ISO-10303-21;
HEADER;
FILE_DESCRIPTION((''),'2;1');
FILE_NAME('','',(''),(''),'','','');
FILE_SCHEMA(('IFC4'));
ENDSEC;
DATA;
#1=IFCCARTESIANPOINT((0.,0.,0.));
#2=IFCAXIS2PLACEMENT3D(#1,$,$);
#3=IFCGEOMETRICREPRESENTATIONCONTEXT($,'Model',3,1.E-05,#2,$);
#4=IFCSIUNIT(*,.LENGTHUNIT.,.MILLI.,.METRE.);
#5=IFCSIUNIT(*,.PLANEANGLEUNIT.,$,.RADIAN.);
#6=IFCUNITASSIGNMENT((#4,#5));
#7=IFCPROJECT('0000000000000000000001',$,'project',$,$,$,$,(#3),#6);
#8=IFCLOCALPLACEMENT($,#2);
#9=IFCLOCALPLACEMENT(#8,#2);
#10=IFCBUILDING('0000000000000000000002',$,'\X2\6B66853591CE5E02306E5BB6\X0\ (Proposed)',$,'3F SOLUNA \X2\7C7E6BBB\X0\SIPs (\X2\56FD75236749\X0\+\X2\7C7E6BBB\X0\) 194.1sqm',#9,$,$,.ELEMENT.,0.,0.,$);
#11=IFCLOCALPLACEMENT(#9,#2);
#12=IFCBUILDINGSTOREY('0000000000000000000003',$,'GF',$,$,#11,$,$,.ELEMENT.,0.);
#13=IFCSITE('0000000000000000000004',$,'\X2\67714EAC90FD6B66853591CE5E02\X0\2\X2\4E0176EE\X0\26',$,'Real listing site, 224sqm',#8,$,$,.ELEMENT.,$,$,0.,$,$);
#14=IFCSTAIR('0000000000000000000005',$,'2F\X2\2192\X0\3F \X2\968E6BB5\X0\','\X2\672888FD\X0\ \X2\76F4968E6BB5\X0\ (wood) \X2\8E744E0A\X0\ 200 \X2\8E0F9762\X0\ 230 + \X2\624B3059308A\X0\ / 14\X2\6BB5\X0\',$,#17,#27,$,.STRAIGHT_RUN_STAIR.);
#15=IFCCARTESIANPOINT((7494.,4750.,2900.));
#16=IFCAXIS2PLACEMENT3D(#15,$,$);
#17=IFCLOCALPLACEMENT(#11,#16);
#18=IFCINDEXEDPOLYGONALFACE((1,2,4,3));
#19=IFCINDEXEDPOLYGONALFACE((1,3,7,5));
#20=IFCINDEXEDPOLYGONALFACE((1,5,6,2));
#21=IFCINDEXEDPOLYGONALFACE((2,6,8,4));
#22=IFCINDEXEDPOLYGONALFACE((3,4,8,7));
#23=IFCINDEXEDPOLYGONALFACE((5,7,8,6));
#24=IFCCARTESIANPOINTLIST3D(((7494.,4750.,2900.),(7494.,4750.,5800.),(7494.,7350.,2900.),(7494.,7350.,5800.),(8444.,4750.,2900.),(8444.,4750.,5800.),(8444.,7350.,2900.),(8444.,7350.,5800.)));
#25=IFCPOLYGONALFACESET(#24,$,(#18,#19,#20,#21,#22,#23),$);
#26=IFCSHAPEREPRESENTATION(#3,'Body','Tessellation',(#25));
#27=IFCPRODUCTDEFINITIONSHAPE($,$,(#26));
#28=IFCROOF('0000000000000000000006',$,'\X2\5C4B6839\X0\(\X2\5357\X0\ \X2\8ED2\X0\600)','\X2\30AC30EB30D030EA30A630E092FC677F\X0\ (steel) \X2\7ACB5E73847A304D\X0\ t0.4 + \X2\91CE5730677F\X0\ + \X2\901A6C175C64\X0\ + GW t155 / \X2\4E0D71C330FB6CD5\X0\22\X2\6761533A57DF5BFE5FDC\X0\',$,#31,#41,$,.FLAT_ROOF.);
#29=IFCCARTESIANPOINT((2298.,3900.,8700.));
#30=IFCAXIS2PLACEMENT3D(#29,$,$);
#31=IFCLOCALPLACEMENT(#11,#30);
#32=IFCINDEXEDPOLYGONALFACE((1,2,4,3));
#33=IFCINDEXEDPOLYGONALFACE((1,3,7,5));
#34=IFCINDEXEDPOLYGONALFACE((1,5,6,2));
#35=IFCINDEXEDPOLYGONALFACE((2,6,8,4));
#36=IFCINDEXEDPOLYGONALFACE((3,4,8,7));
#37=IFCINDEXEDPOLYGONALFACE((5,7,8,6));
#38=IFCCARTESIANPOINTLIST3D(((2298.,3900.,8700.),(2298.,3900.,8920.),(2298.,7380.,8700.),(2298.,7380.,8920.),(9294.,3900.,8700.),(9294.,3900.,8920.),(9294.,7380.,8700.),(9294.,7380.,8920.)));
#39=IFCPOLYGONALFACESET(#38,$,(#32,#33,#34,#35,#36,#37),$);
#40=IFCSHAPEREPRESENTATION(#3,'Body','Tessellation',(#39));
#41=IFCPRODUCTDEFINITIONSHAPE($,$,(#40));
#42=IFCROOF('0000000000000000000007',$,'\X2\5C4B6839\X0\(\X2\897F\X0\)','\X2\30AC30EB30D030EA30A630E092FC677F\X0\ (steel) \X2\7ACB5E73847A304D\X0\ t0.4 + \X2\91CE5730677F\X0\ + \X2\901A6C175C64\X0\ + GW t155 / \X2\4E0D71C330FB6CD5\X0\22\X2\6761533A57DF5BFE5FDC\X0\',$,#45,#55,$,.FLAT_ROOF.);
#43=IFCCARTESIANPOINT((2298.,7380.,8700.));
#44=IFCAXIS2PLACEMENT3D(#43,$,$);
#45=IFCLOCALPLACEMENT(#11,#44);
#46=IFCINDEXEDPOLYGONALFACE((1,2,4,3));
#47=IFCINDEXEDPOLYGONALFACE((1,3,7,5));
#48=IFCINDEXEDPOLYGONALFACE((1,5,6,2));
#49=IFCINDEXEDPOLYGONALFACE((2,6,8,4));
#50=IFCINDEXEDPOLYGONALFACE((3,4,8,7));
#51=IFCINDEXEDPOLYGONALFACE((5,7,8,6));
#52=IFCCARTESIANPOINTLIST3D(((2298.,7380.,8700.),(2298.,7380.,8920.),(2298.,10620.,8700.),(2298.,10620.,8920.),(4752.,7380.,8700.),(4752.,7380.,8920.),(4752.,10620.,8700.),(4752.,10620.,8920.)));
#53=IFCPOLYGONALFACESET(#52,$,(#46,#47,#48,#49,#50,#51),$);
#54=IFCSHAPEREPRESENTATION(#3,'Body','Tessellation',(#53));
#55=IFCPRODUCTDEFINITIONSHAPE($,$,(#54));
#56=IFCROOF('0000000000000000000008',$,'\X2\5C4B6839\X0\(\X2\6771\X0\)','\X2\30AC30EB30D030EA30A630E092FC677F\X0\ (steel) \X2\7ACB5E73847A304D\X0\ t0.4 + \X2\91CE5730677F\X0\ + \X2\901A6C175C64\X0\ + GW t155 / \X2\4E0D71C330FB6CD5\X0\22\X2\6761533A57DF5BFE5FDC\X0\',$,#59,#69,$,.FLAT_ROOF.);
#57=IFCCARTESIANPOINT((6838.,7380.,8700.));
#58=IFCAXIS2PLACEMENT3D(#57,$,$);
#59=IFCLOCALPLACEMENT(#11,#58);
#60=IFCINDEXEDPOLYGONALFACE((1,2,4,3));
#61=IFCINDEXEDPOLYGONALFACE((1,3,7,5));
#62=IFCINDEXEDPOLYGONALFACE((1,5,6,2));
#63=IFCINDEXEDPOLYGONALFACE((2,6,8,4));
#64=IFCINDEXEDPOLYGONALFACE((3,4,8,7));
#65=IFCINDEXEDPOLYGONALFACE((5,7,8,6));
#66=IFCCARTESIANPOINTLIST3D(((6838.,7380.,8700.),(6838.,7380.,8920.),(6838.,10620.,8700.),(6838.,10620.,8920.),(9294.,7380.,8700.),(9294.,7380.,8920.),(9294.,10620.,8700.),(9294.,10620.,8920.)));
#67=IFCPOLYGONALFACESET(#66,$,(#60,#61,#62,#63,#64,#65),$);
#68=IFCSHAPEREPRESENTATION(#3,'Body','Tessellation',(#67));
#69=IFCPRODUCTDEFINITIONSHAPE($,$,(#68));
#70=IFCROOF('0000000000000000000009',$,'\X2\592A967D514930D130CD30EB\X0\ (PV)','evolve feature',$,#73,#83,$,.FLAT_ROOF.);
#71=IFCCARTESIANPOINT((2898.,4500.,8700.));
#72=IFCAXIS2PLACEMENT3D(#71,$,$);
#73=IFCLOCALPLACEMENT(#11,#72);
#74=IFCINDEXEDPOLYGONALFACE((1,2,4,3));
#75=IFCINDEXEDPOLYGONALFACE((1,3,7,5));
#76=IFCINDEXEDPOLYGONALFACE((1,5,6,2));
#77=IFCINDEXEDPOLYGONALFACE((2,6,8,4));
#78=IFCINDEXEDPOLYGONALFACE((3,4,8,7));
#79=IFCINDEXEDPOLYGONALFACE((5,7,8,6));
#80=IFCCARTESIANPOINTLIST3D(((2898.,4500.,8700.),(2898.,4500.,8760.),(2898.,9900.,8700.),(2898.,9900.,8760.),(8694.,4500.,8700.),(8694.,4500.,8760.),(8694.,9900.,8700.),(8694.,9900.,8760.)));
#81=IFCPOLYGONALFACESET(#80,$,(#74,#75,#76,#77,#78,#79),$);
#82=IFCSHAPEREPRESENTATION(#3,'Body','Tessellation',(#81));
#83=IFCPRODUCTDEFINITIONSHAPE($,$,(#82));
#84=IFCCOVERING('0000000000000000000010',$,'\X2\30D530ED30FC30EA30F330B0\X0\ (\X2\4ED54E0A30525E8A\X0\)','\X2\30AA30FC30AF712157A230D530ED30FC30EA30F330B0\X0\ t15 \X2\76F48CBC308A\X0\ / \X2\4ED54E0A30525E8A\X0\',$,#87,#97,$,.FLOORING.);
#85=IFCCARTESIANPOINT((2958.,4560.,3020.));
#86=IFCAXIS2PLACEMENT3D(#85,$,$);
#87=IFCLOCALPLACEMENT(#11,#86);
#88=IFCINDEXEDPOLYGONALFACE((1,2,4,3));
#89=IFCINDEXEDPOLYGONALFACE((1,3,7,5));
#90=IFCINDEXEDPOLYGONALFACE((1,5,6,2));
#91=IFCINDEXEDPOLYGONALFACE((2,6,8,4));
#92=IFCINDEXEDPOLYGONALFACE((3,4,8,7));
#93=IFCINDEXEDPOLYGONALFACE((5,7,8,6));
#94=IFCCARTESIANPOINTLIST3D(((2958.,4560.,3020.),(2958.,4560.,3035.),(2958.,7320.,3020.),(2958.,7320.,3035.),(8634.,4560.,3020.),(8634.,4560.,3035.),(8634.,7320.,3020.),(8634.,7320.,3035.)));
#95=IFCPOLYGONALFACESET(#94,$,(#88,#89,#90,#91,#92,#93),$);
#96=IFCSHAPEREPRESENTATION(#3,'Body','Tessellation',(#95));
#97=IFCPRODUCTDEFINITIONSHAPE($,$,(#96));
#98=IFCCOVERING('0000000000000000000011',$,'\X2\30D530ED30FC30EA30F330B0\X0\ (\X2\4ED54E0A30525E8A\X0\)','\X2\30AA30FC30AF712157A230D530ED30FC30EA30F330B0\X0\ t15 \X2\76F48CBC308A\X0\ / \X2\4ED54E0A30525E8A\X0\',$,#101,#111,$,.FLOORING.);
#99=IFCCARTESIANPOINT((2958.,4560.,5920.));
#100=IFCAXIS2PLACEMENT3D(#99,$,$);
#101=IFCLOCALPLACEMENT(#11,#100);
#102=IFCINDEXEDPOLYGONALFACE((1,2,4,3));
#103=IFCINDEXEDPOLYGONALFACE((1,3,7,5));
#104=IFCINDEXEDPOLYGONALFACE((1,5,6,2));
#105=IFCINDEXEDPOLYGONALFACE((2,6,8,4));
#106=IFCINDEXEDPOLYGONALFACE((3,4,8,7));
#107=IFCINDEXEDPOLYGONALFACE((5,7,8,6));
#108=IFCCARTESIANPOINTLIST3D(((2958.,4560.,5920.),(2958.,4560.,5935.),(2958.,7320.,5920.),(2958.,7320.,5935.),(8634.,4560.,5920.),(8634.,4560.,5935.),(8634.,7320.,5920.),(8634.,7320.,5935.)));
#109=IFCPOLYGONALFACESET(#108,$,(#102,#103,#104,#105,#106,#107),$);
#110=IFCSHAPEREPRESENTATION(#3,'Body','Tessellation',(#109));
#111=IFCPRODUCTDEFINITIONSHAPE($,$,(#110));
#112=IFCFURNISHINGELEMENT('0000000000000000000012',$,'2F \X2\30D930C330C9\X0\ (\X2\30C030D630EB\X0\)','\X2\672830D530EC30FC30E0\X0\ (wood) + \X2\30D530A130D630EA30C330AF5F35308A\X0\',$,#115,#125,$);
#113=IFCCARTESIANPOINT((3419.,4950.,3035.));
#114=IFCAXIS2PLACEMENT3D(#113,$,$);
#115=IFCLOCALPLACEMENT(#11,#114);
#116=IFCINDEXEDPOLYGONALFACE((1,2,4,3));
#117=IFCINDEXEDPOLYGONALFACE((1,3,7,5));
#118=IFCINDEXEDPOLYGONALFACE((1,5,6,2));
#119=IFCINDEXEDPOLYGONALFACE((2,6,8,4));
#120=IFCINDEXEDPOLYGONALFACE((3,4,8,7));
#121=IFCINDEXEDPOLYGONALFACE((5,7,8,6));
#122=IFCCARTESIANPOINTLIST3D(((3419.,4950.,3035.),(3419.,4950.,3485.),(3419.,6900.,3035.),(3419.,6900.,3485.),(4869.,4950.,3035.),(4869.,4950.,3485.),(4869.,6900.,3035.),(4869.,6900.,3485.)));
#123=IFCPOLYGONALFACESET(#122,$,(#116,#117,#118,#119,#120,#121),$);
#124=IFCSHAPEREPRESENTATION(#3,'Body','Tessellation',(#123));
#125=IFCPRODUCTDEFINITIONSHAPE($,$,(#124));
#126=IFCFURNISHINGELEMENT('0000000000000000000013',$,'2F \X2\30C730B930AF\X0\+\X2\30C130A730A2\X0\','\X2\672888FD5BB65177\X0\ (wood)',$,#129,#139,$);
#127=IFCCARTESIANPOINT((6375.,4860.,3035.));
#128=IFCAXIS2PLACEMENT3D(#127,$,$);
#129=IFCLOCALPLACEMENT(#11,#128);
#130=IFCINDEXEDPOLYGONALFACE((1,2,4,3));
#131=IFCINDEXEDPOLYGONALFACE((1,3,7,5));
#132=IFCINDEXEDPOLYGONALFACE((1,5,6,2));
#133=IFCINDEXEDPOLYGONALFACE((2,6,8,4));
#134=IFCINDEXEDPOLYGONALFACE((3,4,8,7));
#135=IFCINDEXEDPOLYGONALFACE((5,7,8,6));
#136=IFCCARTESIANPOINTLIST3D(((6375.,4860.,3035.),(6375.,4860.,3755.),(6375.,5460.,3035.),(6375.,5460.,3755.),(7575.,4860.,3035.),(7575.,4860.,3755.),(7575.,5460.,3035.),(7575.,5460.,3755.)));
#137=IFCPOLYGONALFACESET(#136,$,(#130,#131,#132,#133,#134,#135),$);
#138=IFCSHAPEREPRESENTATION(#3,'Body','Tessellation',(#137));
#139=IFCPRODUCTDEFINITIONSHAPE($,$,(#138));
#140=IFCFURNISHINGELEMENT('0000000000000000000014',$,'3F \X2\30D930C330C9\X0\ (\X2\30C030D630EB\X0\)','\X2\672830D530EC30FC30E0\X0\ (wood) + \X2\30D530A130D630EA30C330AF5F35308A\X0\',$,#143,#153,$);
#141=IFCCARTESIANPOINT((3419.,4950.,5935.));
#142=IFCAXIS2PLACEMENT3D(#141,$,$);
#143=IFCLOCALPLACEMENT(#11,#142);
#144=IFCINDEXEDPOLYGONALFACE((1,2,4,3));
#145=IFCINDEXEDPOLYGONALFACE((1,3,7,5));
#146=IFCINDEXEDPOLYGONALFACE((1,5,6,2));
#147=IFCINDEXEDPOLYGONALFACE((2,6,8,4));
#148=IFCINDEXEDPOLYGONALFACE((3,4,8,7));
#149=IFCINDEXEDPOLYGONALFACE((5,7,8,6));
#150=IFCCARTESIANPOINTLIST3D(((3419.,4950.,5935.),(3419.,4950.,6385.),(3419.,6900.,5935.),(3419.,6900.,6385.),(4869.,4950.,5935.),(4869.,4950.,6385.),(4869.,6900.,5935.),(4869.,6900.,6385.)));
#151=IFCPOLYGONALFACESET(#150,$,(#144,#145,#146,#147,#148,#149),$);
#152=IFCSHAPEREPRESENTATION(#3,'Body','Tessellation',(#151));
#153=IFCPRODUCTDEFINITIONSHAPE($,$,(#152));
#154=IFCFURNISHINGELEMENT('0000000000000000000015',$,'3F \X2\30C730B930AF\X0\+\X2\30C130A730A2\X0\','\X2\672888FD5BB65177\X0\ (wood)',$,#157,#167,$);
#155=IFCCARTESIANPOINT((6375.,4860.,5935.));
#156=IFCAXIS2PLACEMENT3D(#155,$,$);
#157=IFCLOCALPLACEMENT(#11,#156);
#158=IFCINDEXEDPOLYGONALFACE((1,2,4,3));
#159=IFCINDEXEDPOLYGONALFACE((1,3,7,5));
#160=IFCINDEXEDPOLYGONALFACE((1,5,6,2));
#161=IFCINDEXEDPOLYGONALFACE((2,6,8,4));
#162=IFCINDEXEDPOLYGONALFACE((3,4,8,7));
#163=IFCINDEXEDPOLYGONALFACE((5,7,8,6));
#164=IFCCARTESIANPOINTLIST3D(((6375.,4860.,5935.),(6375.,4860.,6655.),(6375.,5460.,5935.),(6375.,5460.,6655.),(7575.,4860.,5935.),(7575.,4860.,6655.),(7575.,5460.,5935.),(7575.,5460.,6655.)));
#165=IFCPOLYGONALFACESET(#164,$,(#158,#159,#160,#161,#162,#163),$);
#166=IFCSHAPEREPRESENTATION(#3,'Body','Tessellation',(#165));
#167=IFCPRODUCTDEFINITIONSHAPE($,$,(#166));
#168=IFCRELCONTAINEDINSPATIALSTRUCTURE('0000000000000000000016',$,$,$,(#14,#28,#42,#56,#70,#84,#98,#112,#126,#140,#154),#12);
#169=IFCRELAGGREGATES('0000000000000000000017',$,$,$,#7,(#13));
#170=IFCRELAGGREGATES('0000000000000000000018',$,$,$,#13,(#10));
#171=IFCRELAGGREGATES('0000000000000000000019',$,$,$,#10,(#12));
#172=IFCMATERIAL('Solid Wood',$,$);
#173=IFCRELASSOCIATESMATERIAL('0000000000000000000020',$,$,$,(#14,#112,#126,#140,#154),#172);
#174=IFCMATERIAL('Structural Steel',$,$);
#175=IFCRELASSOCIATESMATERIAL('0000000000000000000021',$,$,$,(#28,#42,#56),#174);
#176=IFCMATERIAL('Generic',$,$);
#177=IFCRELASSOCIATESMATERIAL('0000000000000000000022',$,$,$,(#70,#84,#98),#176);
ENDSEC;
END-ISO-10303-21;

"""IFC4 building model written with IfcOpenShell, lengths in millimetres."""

from ifc_helpers import new_model, si_unit, frame, frame_2d, origin, place, context, project, spatial, rectangle, extrude, material, element, save


model = new_model("IFC4")

# Units and contexts
model_context = context("Model", 3, precision=1e-05, world=origin())
ifc_project = project(units=[si_unit("LENGTHUNIT", "METRE", prefix="MILLI"), si_unit("PLANEANGLEUNIT", "RADIAN")], contexts=[model_context])

# Site, building, storey
site_placement = place(None, origin())
site = spatial("IfcSite", under=ifc_project, at=site_placement, Name="東京都武蔵野市2丁目26", ObjectType="Real listing site, 224sqm", CompositionType="ELEMENT", RefElevation=0.0)
building_placement = place(site_placement, origin())
building = spatial("IfcBuilding", under=site, at=building_placement, Name="武蔵野市の家 (Proposed)", ObjectType="3F SOLUNA 籾殻SIPs (国産杉+籾殻) 194.1sqm", CompositionType="ELEMENT", ElevationOfRefHeight=0.0, ElevationOfTerrain=0.0)
storey_placement = place(building_placement, origin())
storey = spatial("IfcBuildingStorey", under=building, at=storey_placement, Name="GF", CompositionType="ELEMENT", Elevation=0.0)

# Shared definitions
ifc_material_1 = material(Name="Solid Wood")

# Stair
stair_placement = place(storey_placement, frame((7494.0, 4750.0, 2900.0)))
element("IfcStair", 1, at=stair_placement, inside=storey, material=ifc_material_1, Name="2F→3F 階段", Description="木製 直階段 (wood) 蹴上 200 踏面 230 + 手すり / 14段", PredefinedType="STRAIGHT_RUN_STAIR", context=model_context, shape_type="SweptSolid", body=[
    extrude(rectangle(XDim=950.0, YDim=2600.0, at=frame_2d((475.0, 1300.0))), frame((7494.0, 4750.0, 2900.0)), (0.0, 0.0, 1.0), 2900.0),
])

# Roofs
ifc_material_2 = material(Name="Structural Steel")
roof_1_placement = place(storey_placement, frame((2298.0, 3900.0, 8700.0)))
element("IfcRoof", 2, at=roof_1_placement, inside=storey, material=ifc_material_2, Name="屋根(南 軒600)", Description="ガルバリウム鋼板 (steel) 立平葺き t0.4 + 野地板 + 通気層 + GW t155 / 不燃・法22条区域対応", PredefinedType="FLAT_ROOF", context=model_context, shape_type="SweptSolid", body=[
    extrude(rectangle(XDim=6996.0, YDim=3480.0, at=frame_2d((3498.0, 1740.0))), frame((2298.0, 3900.0, 8700.0)), (0.0, 0.0, 1.0), 220.0),
])
roof_2_placement = place(storey_placement, frame((2298.0, 7380.0, 8700.0)))
element("IfcRoof", 3, at=roof_2_placement, inside=storey, material=ifc_material_2, Name="屋根(西)", Description="ガルバリウム鋼板 (steel) 立平葺き t0.4 + 野地板 + 通気層 + GW t155 / 不燃・法22条区域対応", PredefinedType="FLAT_ROOF", context=model_context, shape_type="SweptSolid", body=[
    extrude(rectangle(XDim=2454.0, YDim=3240.0, at=frame_2d((1227.0, 1620.0))), frame((2298.0, 7380.0, 8700.0)), (0.0, 0.0, 1.0), 220.0),
])
roof_3_placement = place(storey_placement, frame((6838.0, 7380.0, 8700.0)))
element("IfcRoof", 4, at=roof_3_placement, inside=storey, material=ifc_material_2, Name="屋根(東)", Description="ガルバリウム鋼板 (steel) 立平葺き t0.4 + 野地板 + 通気層 + GW t155 / 不燃・法22条区域対応", PredefinedType="FLAT_ROOF", context=model_context, shape_type="SweptSolid", body=[
    extrude(rectangle(XDim=2456.0, YDim=3240.0, at=frame_2d((1228.0, 1620.0))), frame((6838.0, 7380.0, 8700.0)), (0.0, 0.0, 1.0), 220.0),
])
ifc_material_3 = material(Name="Generic")
roof_4_placement = place(storey_placement, frame((2898.0, 4500.0, 8700.0)))
element("IfcRoof", 5, at=roof_4_placement, inside=storey, material=ifc_material_3, Name="太陽光パネル (PV)", Description="evolve feature", PredefinedType="FLAT_ROOF", context=model_context, shape_type="SweptSolid", body=[
    extrude(rectangle(XDim=5796.0, YDim=5400.0, at=frame_2d((2898.0, 2700.0))), frame((2898.0, 4500.0, 8700.0)), (0.0, 0.0, 1.0), 60.0),
])

# Coverings
covering_1_placement = place(storey_placement, frame((2958.0, 4560.0, 3020.0)))
element("IfcCovering", 6, at=covering_1_placement, inside=storey, material=ifc_material_3, Name="フローリング (仕上げ床)", Description="オーク無垢フローリング t15 直貼り / 仕上げ床", PredefinedType="FLOORING", context=model_context, shape_type="SweptSolid", body=[
    extrude(rectangle(XDim=5676.0, YDim=2760.0, at=frame_2d((2838.0, 1380.0))), frame((2958.0, 4560.0, 3020.0)), (0.0, 0.0, 1.0), 15.0),
])
covering_2_placement = place(storey_placement, frame((2958.0, 4560.0, 5920.0)))
element("IfcCovering", 7, at=covering_2_placement, inside=storey, material=ifc_material_3, Name="フローリング (仕上げ床)", Description="オーク無垢フローリング t15 直貼り / 仕上げ床", PredefinedType="FLOORING", context=model_context, shape_type="SweptSolid", body=[
    extrude(rectangle(XDim=5676.0, YDim=2760.0, at=frame_2d((2838.0, 1380.0))), frame((2958.0, 4560.0, 5920.0)), (0.0, 0.0, 1.0), 15.0),
])

# Furnishing elements
furnishing_1_placement = place(storey_placement, frame((3419.0, 4950.0, 3035.0)))
element("IfcFurnishingElement", 8, at=furnishing_1_placement, inside=storey, material=ifc_material_1, Name="2F ベッド (ダブル)", Description="木フレーム (wood) + ファブリック張り", context=model_context, shape_type="SweptSolid", body=[
    extrude(rectangle(XDim=1450.0, YDim=1950.0, at=frame_2d((725.0, 975.0))), frame((3419.0, 4950.0, 3035.0)), (0.0, 0.0, 1.0), 450.0),
])
furnishing_2_placement = place(storey_placement, frame((6375.0, 4860.0, 3035.0)))
element("IfcFurnishingElement", 9, at=furnishing_2_placement, inside=storey, material=ifc_material_1, Name="2F デスク+チェア", Description="木製家具 (wood)", context=model_context, shape_type="SweptSolid", body=[
    extrude(rectangle(XDim=1200.0, YDim=600.0, at=frame_2d((600.0, 300.0))), frame((6375.0, 4860.0, 3035.0)), (0.0, 0.0, 1.0), 720.0),
])
furnishing_3_placement = place(storey_placement, frame((3419.0, 4950.0, 5935.0)))
element("IfcFurnishingElement", 10, at=furnishing_3_placement, inside=storey, material=ifc_material_1, Name="3F ベッド (ダブル)", Description="木フレーム (wood) + ファブリック張り", context=model_context, shape_type="SweptSolid", body=[
    extrude(rectangle(XDim=1450.0, YDim=1950.0, at=frame_2d((725.0, 975.0))), frame((3419.0, 4950.0, 5935.0)), (0.0, 0.0, 1.0), 450.0),
])
furnishing_4_placement = place(storey_placement, frame((6375.0, 4860.0, 5935.0)))
element("IfcFurnishingElement", 11, at=furnishing_4_placement, inside=storey, material=ifc_material_1, Name="3F デスク+チェア", Description="木製家具 (wood)", context=model_context, shape_type="SweptSolid", body=[
    extrude(rectangle(XDim=1200.0, YDim=600.0, at=frame_2d((600.0, 300.0))), frame((6375.0, 4860.0, 5935.0)), (0.0, 0.0, 1.0), 720.0),
])

save(model, "model.ifc")
